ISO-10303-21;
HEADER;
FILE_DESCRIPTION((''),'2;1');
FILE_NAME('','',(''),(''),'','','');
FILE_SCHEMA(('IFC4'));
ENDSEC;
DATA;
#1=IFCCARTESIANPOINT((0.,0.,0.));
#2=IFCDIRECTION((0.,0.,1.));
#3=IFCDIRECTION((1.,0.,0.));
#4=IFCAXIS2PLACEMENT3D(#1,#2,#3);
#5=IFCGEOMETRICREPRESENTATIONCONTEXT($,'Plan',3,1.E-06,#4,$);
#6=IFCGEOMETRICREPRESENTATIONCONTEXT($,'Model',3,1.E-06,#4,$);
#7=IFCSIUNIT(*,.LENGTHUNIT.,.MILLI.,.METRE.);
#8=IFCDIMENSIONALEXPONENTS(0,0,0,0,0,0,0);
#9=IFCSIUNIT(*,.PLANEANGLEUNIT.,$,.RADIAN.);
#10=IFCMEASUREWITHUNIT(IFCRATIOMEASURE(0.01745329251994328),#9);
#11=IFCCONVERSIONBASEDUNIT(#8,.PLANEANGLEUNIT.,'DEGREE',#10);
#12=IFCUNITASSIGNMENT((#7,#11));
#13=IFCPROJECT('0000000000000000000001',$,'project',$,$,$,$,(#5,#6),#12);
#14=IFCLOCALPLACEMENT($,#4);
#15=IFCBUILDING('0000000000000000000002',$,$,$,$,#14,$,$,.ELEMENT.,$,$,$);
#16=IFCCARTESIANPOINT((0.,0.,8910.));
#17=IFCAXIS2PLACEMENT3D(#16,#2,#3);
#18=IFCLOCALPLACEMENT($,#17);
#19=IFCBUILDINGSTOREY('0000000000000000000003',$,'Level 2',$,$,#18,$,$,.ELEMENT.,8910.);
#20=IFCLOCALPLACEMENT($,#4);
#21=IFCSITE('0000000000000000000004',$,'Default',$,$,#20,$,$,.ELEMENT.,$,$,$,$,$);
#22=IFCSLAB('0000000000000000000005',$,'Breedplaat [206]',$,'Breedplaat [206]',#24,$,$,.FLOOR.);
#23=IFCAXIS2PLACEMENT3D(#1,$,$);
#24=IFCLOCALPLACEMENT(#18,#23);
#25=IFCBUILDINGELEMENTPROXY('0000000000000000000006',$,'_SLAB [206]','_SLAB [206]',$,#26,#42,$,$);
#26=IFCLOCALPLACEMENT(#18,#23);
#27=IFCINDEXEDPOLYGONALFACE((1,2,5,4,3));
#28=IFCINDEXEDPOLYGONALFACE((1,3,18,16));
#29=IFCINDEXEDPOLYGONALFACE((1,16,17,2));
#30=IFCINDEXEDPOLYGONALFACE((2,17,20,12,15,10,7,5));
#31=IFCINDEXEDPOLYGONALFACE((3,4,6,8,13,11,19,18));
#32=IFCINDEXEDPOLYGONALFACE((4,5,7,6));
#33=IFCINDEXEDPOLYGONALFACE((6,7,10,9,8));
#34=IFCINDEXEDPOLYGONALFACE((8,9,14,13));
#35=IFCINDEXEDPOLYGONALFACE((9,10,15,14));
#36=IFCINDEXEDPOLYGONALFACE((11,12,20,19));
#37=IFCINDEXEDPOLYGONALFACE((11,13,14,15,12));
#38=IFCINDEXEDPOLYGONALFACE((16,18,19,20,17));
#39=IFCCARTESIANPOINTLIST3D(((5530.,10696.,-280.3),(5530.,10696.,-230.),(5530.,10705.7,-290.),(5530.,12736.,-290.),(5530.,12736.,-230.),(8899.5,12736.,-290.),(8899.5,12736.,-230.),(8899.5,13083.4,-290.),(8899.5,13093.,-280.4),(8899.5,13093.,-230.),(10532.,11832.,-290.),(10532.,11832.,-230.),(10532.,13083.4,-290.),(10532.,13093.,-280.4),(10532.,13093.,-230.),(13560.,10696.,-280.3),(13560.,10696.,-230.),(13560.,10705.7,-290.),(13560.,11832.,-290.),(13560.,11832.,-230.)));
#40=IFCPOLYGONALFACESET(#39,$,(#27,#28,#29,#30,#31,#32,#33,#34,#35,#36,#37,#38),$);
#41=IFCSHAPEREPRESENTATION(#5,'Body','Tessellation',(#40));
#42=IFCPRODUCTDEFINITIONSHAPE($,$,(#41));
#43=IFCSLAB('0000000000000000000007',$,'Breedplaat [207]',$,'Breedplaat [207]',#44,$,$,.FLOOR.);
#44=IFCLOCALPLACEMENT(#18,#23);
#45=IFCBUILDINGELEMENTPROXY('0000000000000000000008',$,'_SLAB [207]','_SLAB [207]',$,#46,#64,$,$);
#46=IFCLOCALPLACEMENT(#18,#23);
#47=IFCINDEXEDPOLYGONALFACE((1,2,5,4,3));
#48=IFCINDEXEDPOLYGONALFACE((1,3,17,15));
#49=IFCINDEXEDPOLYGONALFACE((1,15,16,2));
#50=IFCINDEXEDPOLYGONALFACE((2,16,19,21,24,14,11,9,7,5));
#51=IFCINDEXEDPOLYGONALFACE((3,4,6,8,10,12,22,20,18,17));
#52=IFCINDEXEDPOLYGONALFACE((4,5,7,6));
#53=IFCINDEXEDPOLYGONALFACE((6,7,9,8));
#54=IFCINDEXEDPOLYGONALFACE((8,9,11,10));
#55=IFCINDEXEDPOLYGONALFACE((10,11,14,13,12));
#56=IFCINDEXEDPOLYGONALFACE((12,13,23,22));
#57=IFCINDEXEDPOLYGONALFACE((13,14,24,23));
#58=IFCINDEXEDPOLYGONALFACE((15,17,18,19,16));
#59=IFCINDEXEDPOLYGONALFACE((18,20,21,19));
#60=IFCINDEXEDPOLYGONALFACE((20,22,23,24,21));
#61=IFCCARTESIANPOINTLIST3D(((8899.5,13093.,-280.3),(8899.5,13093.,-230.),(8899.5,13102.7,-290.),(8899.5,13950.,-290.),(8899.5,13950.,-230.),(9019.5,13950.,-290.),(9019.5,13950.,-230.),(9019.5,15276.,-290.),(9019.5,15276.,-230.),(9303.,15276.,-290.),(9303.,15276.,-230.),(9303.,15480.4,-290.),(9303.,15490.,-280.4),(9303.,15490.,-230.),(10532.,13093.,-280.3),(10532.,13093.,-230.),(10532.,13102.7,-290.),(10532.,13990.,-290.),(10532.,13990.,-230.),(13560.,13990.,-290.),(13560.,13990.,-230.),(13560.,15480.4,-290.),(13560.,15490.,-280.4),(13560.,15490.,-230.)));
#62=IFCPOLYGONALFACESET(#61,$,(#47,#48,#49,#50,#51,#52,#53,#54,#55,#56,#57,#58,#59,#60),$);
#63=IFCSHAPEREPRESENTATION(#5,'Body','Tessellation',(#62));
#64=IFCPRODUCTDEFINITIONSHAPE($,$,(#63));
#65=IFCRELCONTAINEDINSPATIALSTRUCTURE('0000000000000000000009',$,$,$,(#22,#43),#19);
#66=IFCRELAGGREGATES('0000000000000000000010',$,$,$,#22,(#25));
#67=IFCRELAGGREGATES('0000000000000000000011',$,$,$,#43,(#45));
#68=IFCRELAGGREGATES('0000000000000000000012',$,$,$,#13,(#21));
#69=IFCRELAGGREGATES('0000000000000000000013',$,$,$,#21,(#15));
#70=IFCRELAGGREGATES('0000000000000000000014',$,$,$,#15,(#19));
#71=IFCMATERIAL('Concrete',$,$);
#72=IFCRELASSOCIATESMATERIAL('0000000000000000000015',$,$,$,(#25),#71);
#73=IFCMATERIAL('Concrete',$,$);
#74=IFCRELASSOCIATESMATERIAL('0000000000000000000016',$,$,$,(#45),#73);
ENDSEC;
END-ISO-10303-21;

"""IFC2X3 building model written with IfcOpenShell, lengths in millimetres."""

from ifc_helpers import new_model, entity, si_unit, converted_unit, frame, origin_with_axes, place, context, project, spatial, polyline, outline, extrude, material, element, aggregate, save


model = new_model("IFC2X3")

# Units and contexts
plan_context = context("Plan", 3, precision=1e-06, world=origin_with_axes())
model_context = context("Model", 3, precision=1e-06, world=origin_with_axes())
ifc_project = project(units=[si_unit("LENGTHUNIT", "METRE", prefix="MILLI"), converted_unit("PLANEANGLEUNIT", "DEGREE", entity("IfcRatioMeasure", 0.01745329251994328), si_unit("PLANEANGLEUNIT", "RADIAN"), dimensions=[0, 0, 0, 0, 0, 0, 0])], contexts=[plan_context, model_context])

# Site, building, storey
site_placement = place(None, origin_with_axes())
site = spatial("IfcSite", under=ifc_project, at=site_placement, Name="Default", CompositionType="ELEMENT")
building_placement = place(None, origin_with_axes())
building = spatial("IfcBuilding", under=site, at=building_placement, CompositionType="ELEMENT")
storey_placement = place(None, frame((0.0, 0.0, 8910.0), z_axis=(0.0, 0.0, 1.0), x_axis=(1.0, 0.0, 0.0)))
storey = spatial("IfcBuildingStorey", under=building, at=storey_placement, Name="Level 2", CompositionType="ELEMENT", Elevation=8910.0)

# Slabs, building element proxies, openings
slab_1_placement = place(None, frame((5530.0, 10696.0, 8620.0), z_axis=(0.0, 0.0, 1.0), x_axis=(1.0, 0.0, 0.0)))
slab_1 = element("IfcSlab", 1, at=slab_1_placement, inside=storey, Name="Breedplaat [206]", ObjectType="Breedplaat [206]", PredefinedType="FLOOR")
ifc_material_1 = material(Name="Concrete")
proxy_1_placement = place(slab_1_placement, origin_with_axes())
proxy_1 = element("IfcBuildingElementProxy", 2, at=proxy_1_placement, material=ifc_material_1, Name="_SLAB [206]", Description="_SLAB [206]", context=plan_context, shape_type="SweptSolid", body=[
    extrude(outline(polyline([(3369.5, 2397.0), (3369.5, 2040.0), (0.0, 2040.0), (0.0, 0.0), (8030.0, 0.0), (8030.0, 1136.0), (5002.0, 1136.0), (5002.0, 2397.0), (3369.5, 2397.0)])), origin_with_axes(), (0.0, 0.0, 1.0), 60.0),
])
opening_1_placement = place(None, frame((5530.0, 10696.0, 8620.0), z_axis=(0.0, 0.0, 1.0), x_axis=(1.0, 0.0, 0.0)))
element("IfcOpeningElement", 3, at=opening_1_placement, cuts=proxy_1, ObjectType="Opening", context=plan_context, shape_type="SweptSolid", body=[
    extrude(outline(polyline([(-0.1, -0.1), (-0.1, 10.0), (10.0, -0.1), (-0.1, -0.1)])), frame((-1.2, -0.1, -0.1), z_axis=(1.0, 0.0, 0.0), x_axis=(0.0, 1.0, 0.0)), (0.0, 0.0, 1.0), 8032.2),
])
opening_2_placement = place(None, frame((5530.0, 10696.0, 8620.0), z_axis=(0.0, 0.0, 1.0), x_axis=(1.0, 0.0, 0.0)))
element("IfcOpeningElement", 4, at=opening_2_placement, cuts=proxy_1, ObjectType="Opening", context=plan_context, shape_type="SweptSolid", body=[
    extrude(outline(polyline([(-0.1, -0.1), (-0.1, 10.0), (10.0, -0.1), (-0.1, -0.1)])), frame((5003.2, 2397.2, -0.1), z_axis=(-1.0, 0.0, 0.0), x_axis=(0.0, -1.0, 0.0)), (0.0, 0.0, 1.0), 1634.7),
])
aggregate(slab_1, [proxy_1])
slab_2_placement = place(None, frame((8899.5, 13093.0, 8620.0), z_axis=(0.0, 0.0, 1.0), x_axis=(1.0, 0.0, 0.0)))
slab_2 = element("IfcSlab", 5, at=slab_2_placement, inside=storey, Name="Breedplaat [207]", ObjectType="Breedplaat [207]", PredefinedType="FLOOR")
ifc_material_2 = material(Name="Concrete")
proxy_2_placement = place(slab_2_placement, origin_with_axes())
proxy_2 = element("IfcBuildingElementProxy", 6, at=proxy_2_placement, material=ifc_material_2, Name="_SLAB [207]", Description="_SLAB [207]", context=plan_context, shape_type="SweptSolid", body=[
    extrude(outline(polyline([(1632.5, 0.0), (1632.5, 897.0), (4660.6, 897.0), (4660.6, 2397.0), (403.6, 2397.0), (403.6, 2183.0), (120.0, 2183.0), (120.0, 857.0), (0.0, 857.0), (0.0, 0.0), (1632.5, 0.0)])), origin_with_axes(), (0.0, 0.0, 1.0), 60.0),
])
opening_3_placement = place(None, frame((8899.5, 13093.0, 8620.0), z_axis=(0.0, 0.0, 1.0), x_axis=(1.0, 0.0, 0.0)))
element("IfcOpeningElement", 7, at=opening_3_placement, cuts=proxy_2, ObjectType="Opening", context=plan_context, shape_type="SweptSolid", body=[
    extrude(outline(polyline([(-0.1, -0.1), (-0.1, 10.0), (10.0, -0.1), (-0.1, -0.1)])), frame((-1.2, -0.1, -0.1), z_axis=(1.0, 0.0, 0.0), x_axis=(0.0, 1.0, 0.0)), (0.0, 0.0, 1.0), 1634.8),
])
opening_4_placement = place(None, frame((8899.5, 13093.0, 8620.0), z_axis=(0.0, 0.0, 1.0), x_axis=(1.0, 0.0, 0.0)))
element("IfcOpeningElement", 8, at=opening_4_placement, cuts=proxy_2, ObjectType="Opening", context=plan_context, shape_type="SweptSolid", body=[
    extrude(outline(polyline([(-0.1, -0.1), (-0.1, 10.0), (10.0, -0.1), (-0.1, -0.1)])), frame((4661.8, 2397.2, -0.1), z_axis=(-1.0, 0.0, 0.0), x_axis=(0.0, -1.0, 0.0)), (0.0, 0.0, 1.0), 4259.2),
])
aggregate(slab_2, [proxy_2])

save(model, "model.ifc")
